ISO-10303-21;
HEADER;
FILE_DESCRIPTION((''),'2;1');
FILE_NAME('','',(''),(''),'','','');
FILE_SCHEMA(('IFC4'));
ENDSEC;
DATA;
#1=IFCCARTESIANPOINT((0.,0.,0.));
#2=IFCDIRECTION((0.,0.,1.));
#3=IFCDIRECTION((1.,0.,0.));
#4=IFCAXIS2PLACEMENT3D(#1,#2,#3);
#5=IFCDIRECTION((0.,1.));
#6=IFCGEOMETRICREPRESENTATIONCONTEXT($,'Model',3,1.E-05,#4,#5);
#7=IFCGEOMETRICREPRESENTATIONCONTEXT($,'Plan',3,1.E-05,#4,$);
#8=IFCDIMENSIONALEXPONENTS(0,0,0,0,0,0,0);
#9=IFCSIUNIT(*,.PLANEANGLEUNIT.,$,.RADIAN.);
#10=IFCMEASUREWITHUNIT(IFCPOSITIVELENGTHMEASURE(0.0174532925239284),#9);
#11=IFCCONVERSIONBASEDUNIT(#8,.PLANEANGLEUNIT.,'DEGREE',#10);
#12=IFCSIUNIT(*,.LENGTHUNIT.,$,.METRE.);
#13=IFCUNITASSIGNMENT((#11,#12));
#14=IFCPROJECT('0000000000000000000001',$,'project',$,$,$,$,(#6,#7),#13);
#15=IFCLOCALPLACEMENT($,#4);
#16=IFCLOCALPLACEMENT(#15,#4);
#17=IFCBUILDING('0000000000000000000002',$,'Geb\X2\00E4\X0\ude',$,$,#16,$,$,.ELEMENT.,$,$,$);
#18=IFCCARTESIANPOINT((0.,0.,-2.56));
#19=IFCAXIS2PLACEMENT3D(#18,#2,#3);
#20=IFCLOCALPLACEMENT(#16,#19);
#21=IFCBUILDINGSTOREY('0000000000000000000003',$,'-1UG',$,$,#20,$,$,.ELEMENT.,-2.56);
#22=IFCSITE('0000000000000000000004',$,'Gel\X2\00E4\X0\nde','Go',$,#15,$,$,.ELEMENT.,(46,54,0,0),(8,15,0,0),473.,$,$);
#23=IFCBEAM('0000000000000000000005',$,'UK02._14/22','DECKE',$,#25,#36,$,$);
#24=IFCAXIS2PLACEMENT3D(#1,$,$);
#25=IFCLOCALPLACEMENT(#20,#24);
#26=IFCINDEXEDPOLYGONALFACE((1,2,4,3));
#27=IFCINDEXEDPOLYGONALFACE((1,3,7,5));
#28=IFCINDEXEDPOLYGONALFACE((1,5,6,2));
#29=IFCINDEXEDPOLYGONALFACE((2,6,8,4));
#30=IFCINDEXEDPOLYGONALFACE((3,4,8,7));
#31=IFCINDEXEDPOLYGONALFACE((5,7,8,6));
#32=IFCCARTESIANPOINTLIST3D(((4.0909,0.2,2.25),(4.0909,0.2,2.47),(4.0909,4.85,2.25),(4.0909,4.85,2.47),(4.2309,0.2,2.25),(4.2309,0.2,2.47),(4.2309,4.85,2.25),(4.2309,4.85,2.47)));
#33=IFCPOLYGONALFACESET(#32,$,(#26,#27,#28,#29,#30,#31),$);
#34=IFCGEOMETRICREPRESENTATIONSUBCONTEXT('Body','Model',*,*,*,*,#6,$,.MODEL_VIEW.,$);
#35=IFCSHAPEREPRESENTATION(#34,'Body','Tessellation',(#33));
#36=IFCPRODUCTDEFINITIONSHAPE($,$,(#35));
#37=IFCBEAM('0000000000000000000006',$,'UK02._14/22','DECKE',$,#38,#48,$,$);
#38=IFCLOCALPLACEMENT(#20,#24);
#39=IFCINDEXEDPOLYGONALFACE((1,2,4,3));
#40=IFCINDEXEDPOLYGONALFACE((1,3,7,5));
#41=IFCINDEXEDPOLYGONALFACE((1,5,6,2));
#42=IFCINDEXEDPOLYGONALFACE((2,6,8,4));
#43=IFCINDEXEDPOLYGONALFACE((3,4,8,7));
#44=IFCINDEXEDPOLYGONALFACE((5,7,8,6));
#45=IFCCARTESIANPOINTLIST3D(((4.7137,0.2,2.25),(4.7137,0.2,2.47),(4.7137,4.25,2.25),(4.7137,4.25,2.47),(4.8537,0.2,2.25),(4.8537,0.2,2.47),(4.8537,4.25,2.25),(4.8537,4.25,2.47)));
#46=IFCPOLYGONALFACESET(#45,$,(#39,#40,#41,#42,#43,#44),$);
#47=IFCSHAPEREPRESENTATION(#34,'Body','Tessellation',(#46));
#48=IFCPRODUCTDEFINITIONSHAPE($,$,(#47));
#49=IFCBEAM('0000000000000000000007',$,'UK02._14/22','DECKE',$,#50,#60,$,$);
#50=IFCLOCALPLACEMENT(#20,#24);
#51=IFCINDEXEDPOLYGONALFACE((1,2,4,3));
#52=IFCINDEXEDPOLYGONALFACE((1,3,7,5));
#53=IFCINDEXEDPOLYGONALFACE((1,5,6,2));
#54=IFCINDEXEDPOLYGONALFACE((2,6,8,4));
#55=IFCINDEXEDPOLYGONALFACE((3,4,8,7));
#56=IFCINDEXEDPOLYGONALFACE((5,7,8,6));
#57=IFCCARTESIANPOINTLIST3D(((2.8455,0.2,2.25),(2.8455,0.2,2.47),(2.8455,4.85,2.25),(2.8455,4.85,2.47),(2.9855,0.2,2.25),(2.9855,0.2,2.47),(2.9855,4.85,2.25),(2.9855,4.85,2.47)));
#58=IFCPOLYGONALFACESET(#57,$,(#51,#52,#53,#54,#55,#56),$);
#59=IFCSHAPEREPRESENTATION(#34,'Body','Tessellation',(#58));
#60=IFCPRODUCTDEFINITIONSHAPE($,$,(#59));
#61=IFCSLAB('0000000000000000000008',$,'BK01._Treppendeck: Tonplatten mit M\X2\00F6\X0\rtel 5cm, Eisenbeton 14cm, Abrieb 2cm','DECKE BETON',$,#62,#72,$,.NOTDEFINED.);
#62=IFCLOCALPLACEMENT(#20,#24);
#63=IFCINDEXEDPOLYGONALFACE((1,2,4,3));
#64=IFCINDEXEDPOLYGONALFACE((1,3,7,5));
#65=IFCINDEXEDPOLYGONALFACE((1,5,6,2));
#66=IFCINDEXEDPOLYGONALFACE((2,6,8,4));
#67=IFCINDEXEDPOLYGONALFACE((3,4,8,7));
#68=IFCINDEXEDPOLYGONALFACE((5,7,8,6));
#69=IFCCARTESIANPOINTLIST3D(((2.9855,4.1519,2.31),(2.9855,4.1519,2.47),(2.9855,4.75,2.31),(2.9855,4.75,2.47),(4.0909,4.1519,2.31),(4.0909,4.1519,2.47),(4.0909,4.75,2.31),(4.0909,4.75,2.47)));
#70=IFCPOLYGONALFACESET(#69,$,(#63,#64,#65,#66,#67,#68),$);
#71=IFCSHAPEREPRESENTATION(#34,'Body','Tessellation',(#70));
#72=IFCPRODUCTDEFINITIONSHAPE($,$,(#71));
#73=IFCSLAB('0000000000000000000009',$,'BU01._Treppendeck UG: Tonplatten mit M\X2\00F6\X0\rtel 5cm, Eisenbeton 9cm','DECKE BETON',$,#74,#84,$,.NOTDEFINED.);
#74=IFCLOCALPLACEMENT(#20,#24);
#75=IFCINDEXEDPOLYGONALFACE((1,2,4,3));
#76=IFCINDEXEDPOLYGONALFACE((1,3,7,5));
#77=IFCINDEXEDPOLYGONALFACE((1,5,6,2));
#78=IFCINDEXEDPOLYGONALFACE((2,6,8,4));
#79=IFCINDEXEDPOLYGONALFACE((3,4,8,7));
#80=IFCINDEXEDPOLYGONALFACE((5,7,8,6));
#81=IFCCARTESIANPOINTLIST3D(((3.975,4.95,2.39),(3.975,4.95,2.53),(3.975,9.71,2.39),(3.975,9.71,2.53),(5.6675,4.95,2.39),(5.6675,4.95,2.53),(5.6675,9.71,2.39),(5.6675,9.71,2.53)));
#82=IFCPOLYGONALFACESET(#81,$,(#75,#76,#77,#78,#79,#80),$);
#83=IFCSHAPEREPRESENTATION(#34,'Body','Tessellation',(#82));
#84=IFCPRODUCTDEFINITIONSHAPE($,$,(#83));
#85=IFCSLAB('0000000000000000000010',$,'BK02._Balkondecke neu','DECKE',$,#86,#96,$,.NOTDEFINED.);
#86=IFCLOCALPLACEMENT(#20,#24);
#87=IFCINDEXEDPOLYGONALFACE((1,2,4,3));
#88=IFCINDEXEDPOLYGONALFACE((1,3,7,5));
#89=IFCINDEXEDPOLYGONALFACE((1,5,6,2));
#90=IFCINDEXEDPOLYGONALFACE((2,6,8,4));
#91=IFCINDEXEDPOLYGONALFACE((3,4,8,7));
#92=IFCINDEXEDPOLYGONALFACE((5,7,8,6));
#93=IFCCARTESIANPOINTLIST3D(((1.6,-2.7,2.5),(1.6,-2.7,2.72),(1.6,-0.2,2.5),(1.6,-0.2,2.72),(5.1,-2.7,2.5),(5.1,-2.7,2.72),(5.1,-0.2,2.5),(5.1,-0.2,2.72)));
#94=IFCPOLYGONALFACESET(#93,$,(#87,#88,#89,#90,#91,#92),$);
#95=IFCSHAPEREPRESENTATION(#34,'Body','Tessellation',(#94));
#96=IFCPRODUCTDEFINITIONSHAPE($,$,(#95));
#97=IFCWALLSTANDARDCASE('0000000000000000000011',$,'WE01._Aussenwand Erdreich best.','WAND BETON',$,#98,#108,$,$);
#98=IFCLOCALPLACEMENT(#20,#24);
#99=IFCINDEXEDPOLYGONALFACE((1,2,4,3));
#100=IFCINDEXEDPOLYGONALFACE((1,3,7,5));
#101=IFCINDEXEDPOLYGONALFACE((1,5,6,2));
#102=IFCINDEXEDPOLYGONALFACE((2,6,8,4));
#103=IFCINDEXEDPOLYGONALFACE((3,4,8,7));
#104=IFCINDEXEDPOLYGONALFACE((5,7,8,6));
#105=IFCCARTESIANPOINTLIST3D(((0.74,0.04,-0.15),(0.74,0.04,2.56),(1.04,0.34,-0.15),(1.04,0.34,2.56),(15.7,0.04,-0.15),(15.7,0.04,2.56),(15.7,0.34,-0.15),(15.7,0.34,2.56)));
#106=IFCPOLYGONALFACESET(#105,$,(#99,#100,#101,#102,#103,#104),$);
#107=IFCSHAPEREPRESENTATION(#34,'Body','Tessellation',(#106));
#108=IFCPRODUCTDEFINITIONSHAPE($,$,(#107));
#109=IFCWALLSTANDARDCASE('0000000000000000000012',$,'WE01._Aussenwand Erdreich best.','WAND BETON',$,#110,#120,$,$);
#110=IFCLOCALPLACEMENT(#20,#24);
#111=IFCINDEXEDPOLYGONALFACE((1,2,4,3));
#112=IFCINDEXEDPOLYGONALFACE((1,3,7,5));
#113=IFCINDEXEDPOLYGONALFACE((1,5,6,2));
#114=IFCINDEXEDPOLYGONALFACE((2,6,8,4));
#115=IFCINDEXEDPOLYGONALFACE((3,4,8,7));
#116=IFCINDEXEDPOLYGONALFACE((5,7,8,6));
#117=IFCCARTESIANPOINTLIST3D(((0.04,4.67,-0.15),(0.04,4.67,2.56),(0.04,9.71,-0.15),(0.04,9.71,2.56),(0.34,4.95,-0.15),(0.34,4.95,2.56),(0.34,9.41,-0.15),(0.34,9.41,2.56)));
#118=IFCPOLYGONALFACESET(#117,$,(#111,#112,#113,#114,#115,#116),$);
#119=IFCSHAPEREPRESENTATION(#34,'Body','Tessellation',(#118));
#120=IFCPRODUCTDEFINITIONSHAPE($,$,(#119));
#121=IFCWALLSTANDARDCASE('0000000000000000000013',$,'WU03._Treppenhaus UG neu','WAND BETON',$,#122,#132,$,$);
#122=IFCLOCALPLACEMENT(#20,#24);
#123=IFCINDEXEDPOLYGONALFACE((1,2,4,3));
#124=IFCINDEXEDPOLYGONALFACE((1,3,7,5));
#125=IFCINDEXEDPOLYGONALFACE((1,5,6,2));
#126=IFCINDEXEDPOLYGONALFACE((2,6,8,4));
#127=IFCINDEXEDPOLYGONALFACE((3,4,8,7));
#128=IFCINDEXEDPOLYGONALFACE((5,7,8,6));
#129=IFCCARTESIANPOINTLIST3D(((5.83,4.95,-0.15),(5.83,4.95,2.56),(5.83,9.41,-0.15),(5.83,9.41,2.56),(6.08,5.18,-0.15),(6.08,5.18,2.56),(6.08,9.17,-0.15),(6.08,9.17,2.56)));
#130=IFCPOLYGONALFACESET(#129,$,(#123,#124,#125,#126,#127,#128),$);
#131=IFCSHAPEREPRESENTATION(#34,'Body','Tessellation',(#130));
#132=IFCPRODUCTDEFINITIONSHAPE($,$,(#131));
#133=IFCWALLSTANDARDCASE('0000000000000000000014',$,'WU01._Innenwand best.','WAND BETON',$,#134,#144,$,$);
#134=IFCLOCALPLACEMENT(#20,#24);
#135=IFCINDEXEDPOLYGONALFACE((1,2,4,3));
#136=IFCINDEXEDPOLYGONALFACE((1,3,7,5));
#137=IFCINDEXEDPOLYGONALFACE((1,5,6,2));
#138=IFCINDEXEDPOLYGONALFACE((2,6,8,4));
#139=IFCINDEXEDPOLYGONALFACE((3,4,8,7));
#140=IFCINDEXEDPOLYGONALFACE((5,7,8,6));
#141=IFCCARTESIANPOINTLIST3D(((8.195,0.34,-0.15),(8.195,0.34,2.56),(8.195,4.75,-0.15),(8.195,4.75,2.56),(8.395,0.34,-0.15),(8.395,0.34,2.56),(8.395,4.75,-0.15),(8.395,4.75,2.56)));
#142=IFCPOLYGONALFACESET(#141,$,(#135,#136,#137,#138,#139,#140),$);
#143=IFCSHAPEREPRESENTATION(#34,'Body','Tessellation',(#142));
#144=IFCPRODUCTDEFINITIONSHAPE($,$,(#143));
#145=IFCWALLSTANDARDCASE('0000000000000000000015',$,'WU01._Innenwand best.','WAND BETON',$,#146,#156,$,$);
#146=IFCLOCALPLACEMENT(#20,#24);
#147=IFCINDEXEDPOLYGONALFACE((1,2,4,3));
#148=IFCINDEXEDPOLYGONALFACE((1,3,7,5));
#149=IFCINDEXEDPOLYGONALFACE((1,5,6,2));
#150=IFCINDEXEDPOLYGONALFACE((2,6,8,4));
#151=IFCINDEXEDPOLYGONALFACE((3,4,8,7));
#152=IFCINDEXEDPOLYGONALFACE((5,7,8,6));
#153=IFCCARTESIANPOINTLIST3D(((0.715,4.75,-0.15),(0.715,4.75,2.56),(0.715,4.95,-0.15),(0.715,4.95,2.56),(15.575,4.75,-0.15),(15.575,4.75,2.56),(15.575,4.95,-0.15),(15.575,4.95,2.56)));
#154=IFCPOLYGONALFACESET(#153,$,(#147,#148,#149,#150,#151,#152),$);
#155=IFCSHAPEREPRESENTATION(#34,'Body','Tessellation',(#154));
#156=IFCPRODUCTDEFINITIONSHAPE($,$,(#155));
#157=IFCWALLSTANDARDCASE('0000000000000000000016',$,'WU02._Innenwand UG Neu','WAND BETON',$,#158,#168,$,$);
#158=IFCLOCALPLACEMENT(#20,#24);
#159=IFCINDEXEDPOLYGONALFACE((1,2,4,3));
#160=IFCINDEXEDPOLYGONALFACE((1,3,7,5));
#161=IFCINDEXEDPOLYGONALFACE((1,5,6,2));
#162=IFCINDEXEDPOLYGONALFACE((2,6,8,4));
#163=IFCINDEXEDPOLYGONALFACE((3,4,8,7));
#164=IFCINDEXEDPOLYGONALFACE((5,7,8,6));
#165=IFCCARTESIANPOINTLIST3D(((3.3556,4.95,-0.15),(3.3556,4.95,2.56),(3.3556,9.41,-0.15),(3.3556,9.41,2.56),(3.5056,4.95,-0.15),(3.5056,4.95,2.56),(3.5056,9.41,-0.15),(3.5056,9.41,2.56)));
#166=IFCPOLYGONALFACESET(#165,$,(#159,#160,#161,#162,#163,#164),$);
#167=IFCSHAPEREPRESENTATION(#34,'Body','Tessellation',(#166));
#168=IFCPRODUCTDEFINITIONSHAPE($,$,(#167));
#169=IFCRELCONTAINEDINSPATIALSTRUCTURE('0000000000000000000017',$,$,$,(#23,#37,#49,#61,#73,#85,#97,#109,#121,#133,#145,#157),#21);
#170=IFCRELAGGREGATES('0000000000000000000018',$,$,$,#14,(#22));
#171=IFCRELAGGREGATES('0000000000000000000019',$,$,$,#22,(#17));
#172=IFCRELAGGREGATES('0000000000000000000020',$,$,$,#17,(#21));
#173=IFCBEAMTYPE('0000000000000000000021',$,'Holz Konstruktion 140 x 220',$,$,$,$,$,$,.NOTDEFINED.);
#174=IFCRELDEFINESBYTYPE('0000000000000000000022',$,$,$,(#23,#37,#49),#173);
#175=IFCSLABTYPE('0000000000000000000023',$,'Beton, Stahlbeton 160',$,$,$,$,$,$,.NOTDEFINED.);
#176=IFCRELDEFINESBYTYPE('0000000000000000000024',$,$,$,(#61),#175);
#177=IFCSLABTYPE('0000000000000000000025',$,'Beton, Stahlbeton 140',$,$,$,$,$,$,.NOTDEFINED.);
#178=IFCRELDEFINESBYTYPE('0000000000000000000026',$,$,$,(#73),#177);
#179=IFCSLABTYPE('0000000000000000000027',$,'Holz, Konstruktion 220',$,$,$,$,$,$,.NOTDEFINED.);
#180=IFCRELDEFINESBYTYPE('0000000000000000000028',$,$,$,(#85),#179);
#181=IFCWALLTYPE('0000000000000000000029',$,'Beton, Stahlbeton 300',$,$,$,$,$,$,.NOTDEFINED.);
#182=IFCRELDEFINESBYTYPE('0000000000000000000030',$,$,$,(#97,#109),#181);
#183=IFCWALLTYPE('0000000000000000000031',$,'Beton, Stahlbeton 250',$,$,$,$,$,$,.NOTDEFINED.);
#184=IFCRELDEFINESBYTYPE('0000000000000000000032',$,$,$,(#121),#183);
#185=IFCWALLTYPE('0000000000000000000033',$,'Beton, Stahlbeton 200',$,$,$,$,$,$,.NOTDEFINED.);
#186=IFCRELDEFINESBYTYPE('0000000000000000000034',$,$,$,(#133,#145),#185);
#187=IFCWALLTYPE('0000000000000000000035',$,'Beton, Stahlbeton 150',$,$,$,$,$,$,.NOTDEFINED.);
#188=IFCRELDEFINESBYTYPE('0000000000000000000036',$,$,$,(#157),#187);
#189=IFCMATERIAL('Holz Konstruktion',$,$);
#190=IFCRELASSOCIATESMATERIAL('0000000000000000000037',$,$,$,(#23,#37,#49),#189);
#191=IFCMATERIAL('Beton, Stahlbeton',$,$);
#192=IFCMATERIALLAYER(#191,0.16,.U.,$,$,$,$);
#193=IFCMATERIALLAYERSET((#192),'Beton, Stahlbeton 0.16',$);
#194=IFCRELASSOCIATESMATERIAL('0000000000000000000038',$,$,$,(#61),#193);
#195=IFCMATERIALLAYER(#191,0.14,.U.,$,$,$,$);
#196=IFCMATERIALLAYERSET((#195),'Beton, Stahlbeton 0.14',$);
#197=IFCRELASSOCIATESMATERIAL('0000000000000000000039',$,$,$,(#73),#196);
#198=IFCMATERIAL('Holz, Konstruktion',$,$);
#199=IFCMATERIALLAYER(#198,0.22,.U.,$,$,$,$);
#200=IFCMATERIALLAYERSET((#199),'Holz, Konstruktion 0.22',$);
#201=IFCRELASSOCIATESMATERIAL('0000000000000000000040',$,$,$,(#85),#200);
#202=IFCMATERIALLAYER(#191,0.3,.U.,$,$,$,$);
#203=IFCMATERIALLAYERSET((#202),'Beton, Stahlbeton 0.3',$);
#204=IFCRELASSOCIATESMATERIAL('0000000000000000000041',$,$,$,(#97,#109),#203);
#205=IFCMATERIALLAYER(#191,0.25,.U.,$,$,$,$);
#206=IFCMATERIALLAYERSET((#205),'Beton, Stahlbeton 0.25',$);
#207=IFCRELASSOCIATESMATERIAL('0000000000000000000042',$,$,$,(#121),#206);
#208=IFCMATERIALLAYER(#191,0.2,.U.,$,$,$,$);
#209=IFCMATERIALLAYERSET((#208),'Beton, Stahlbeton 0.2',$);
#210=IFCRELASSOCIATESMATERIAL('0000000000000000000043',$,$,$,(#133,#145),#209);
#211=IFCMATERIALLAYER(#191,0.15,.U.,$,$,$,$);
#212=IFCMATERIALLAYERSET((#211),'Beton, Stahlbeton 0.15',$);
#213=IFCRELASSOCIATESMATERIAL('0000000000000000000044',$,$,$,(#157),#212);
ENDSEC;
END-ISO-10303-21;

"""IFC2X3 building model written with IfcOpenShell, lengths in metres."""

from ifc_helpers import new_model, entity, si_unit, converted_unit, direction, frame, frame_2d, origin_with_axes, place, context, subcontext, project, spatial, polyline, rectangle, outline, extrude, material, layer, layer_set, layer_usage, type_object, element, save


model = new_model("IFC2X3")

# Units and contexts
model_context = context("Model", 3, precision=1e-05, world=origin_with_axes(), true_north=direction((0.0, 1.0)))
plan_context = context("Plan", 3, precision=1e-05, world=origin_with_axes())
body_context = subcontext(model_context, "Body", "Model", "MODEL_VIEW")
ifc_project = project(units=[converted_unit("PLANEANGLEUNIT", "DEGREE", entity("IfcPositiveLengthMeasure", 0.0174532925239284), si_unit("PLANEANGLEUNIT", "RADIAN"), dimensions=[0, 0, 0, 0, 0, 0, 0]), si_unit("LENGTHUNIT", "METRE")], contexts=[model_context, plan_context])

# Site, building, storey
site_placement = place(None, origin_with_axes())
site = spatial("IfcSite", under=ifc_project, at=site_placement, Name="Gelände", Description="Go", CompositionType="ELEMENT", RefLatitude=(46, 54, 0, 0), RefLongitude=(8, 15, 0, 0), RefElevation=473.0)
building_placement = place(site_placement, origin_with_axes())
building = spatial("IfcBuilding", under=site, at=building_placement, Name="Gebäude", CompositionType="ELEMENT")
storey_placement = place(building_placement, frame((0.0, 0.0, -2.56), z_axis=(0.0, 0.0, 1.0), x_axis=(1.0, 0.0, 0.0)))
storey = spatial("IfcBuildingStorey", under=building, at=storey_placement, Name="-1UG", CompositionType="ELEMENT", Elevation=-2.56)

# Shared definitions
ifc_material_1 = material(Name="Beton, Stahlbeton")

# Beams
ifc_material_2 = material(Name="Holz Konstruktion")
beam_type_1 = type_object("IfcBeamType", Name="Holz Konstruktion 140 x 220", PredefinedType="NOTDEFINED")
for number, where, z_axis, x_axis, name in (
    (1, (4.1609, 0.2, 2.47), (0.0, 0.0, 1.0), (1.0, 0.0, 0.0), "UK02._14/22"),
):
    element("IfcBeam", number, at=place(storey_placement, frame(where, z_axis=z_axis, x_axis=x_axis)), inside=storey, type_object=beam_type_1, material=ifc_material_2, Name=name, Description="DECKE", context=body_context, shape_type="SweptSolid", body=[
        extrude(rectangle(XDim=0.22, YDim=0.14, at=frame_2d((-0.11, 0.0), x_axis=(1.0, 0.0))), frame((0.0, 0.0, 0.0), z_axis=(0.0, 1.0, 0.0), x_axis=(0.0, 0.0, 1.0)), (0.0, 0.0, 1.0), 4.65),
    ])
beam_1_placement = place(storey_placement, frame((4.7837, 0.2, 2.47), z_axis=(0.0, 0.0, 1.0), x_axis=(1.0, 0.0, 0.0)))
element("IfcBeam", 2, at=beam_1_placement, inside=storey, type_object=beam_type_1, material=ifc_material_2, Name="UK02._14/22", Description="DECKE", context=body_context, shape_type="SweptSolid", body=[
    extrude(rectangle(XDim=0.22, YDim=0.14, at=frame_2d((-0.11, 0.0), x_axis=(1.0, 0.0))), frame((0.0, 0.0, 0.0), z_axis=(0.0, 1.0, 0.0), x_axis=(0.0, 0.0, 1.0)), (0.0, 0.0, 1.0), 4.05),
])
beam_2_placement = place(storey_placement, frame((2.9155, 0.2, 2.47), z_axis=(0.0, 0.0, 1.0), x_axis=(1.0, 0.0, 0.0)))
element("IfcBeam", 3, at=beam_2_placement, inside=storey, type_object=beam_type_1, material=ifc_material_2, Name="UK02._14/22", Description="DECKE", context=body_context, shape_type="SweptSolid", body=[
    extrude(rectangle(XDim=0.22, YDim=0.14, at=frame_2d((-0.11, 0.0), x_axis=(1.0, 0.0))), frame((0.0, 0.0, 0.0), z_axis=(0.0, 1.0, 0.0), x_axis=(0.0, 0.0, 1.0)), (0.0, 0.0, 1.0), 4.65),
])

# Slabs
ifc_layer_1 = layer(ifc_material_1, 0.16, ventilated="UNKNOWN")
ifc_layer_set_1 = layer_set([ifc_layer_1], Name="Beton, Stahlbeton 0.16")
ifc_layer_usage_1 = layer_usage(ifc_layer_set_1, "AXIS3", "NEGATIVE", 0.16)
slab_type_1 = type_object("IfcSlabType", Name="Beton, Stahlbeton 160", PredefinedType="NOTDEFINED")
slab_1_placement = place(storey_placement, frame((4.0909, 4.1519, 2.47), z_axis=(0.0, 0.0, 1.0), x_axis=(1.0, 0.0, 0.0)))
element("IfcSlab", 4, at=slab_1_placement, inside=storey, type_object=slab_type_1, material=ifc_layer_usage_1, Name="BK01._Treppendeck: Tonplatten mit Mörtel 5cm, Eisenbeton 14cm, Abrieb 2cm", Description="DECKE BETON", PredefinedType="NOTDEFINED", context=body_context, shape_type="SweptSolid", body=[
    extrude(outline(polyline([(0.0, 0.0), (0.0, 0.5981), (-1.1054, 0.5981), (-1.1054, 0.0), (0.0, 0.0)])), frame((0.0, 0.0, -0.16), z_axis=(0.0, 0.0, 1.0), x_axis=(1.0, 0.0, 0.0)), (0.0, 0.0, 1.0), 0.16),
])
ifc_layer_2 = layer(ifc_material_1, 0.14, ventilated="UNKNOWN")
ifc_layer_set_2 = layer_set([ifc_layer_2], Name="Beton, Stahlbeton 0.14")
ifc_layer_usage_2 = layer_usage(ifc_layer_set_2, "AXIS3", "NEGATIVE", 0.14)
slab_type_2 = type_object("IfcSlabType", Name="Beton, Stahlbeton 140", PredefinedType="NOTDEFINED")
slab_2_placement = place(storey_placement, frame((5.6675, 4.95, 2.53), z_axis=(0.0, 0.0, 1.0), x_axis=(1.0, 0.0, 0.0)))
element("IfcSlab", 5, at=slab_2_placement, inside=storey, type_object=slab_type_2, material=ifc_layer_usage_2, Name="BU01._Treppendeck UG: Tonplatten mit Mörtel 5cm, Eisenbeton 9cm", Description="DECKE BETON", PredefinedType="NOTDEFINED", context=body_context, shape_type="SweptSolid", body=[
    extrude(outline(polyline([(0.0, 0.0), (0.0, 4.76), (-1.6925, 4.76), (-1.6925, 0.0), (0.0, 0.0)])), frame((0.0, 0.0, -0.14), z_axis=(0.0, 0.0, 1.0), x_axis=(1.0, 0.0, 0.0)), (0.0, 0.0, 1.0), 0.14),
])
ifc_material_3 = material(Name="Holz, Konstruktion")
ifc_layer_3 = layer(ifc_material_3, 0.22, ventilated="UNKNOWN")
ifc_layer_set_3 = layer_set([ifc_layer_3], Name="Holz, Konstruktion 0.22")
ifc_layer_usage_3 = layer_usage(ifc_layer_set_3, "AXIS3", "NEGATIVE", 0.22)
slab_type_3 = type_object("IfcSlabType", Name="Holz, Konstruktion 220", PredefinedType="NOTDEFINED")
slab_3_placement = place(storey_placement, frame((1.6, -2.7, 2.72), z_axis=(0.0, 0.0, 1.0), x_axis=(1.0, 0.0, 0.0)))
element("IfcSlab", 6, at=slab_3_placement, inside=storey, type_object=slab_type_3, material=ifc_layer_usage_3, Name="BK02._Balkondecke neu", Description="DECKE", PredefinedType="NOTDEFINED", context=body_context, shape_type="SweptSolid", body=[
    extrude(outline(polyline([(0.0, 0.0), (3.5, 0.0), (3.5, 2.5), (0.0, 2.5), (0.0, 0.0)])), frame((0.0, 0.0, -0.22), z_axis=(0.0, 0.0, 1.0), x_axis=(1.0, 0.0, 0.0)), (0.0, 0.0, 1.0), 0.22),
])

# Walls
ifc_layer_4 = layer(ifc_material_1, 0.3, ventilated="UNKNOWN")
ifc_layer_set_4 = layer_set([ifc_layer_4], Name="Beton, Stahlbeton 0.3")
wall_type_1 = type_object("IfcWallType", Name="Beton, Stahlbeton 300", PredefinedType="NOTDEFINED")
ifc_layer_usage_4 = layer_usage(ifc_layer_set_4, "AXIS2", "POSITIVE", -0.3)
wall_1_placement = place(storey_placement, frame((1.04, 0.34, -0.15), z_axis=(0.0, 0.0, 1.0), x_axis=(1.0, 0.0, 0.0)))
element("IfcWallStandardCase", 7, at=wall_1_placement, inside=storey, type_object=wall_type_1, material=ifc_layer_usage_4, Name="WE01._Aussenwand Erdreich best.", Description="WAND BETON", context=body_context, shape_type="SweptSolid", body=[
    extrude(outline(polyline([(-0.3, -0.3), (14.66, -0.3), (14.66, 0.0), (0.0, 0.0), (-0.3, -0.3)])), origin_with_axes(), (0.0, 0.0, 1.0), 2.71),
])
ifc_layer_usage_5 = layer_usage(ifc_layer_set_4, "AXIS2", "POSITIVE", -0.3)
wall_2_placement = place(storey_placement, frame((0.34, 9.41, -0.15), z_axis=(0.0, 0.0, 1.0), x_axis=(0.0, -1.0, 0.0)))
element("IfcWallStandardCase", 8, at=wall_2_placement, inside=storey, type_object=wall_type_1, material=ifc_layer_usage_5, Name="WE01._Aussenwand Erdreich best.", Description="WAND BETON", context=body_context, shape_type="SweptSolid", body=[
    extrude(outline(polyline([(-0.3, -0.3), (4.74, -0.3), (4.46, 0.0), (0.0, 0.0), (-0.3, -0.3)])), origin_with_axes(), (0.0, 0.0, 1.0), 2.71),
])
ifc_layer_5 = layer(ifc_material_1, 0.25, ventilated="UNKNOWN")
ifc_layer_set_5 = layer_set([ifc_layer_5], Name="Beton, Stahlbeton 0.25")
ifc_layer_usage_6 = layer_usage(ifc_layer_set_5, "AXIS2", "POSITIVE", -0.25)
wall_type_2 = type_object("IfcWallType", Name="Beton, Stahlbeton 250", PredefinedType="NOTDEFINED")
wall_3_placement = place(storey_placement, frame((6.08, 9.17, -0.15), z_axis=(0.0, 0.0, 1.0), x_axis=(0.0, -1.0, 0.0)))
element("IfcWallStandardCase", 9, at=wall_3_placement, inside=storey, type_object=wall_type_2, material=ifc_layer_usage_6, Name="WU03._Treppenhaus UG neu", Description="WAND BETON", context=body_context, shape_type="SweptSolid", body=[
    extrude(outline(polyline([(-0.24, -0.25), (4.22, -0.25), (3.99, 0.0), (0.0, 0.0), (-0.24, -0.25)])), origin_with_axes(), (0.0, 0.0, 1.0), 2.71),
])
ifc_layer_6 = layer(ifc_material_1, 0.2, ventilated="UNKNOWN")
ifc_layer_set_6 = layer_set([ifc_layer_6], Name="Beton, Stahlbeton 0.2")
ifc_layer_usage_7 = layer_usage(ifc_layer_set_6, "AXIS2", "POSITIVE", 0.0)
wall_type_3 = type_object("IfcWallType", Name="Beton, Stahlbeton 200", PredefinedType="NOTDEFINED")
wall_4_placement = place(storey_placement, frame((8.395, 0.34, -0.15), z_axis=(0.0, 0.0, 1.0), x_axis=(0.0, 1.0, 0.0)))
element("IfcWallStandardCase", 10, at=wall_4_placement, inside=storey, type_object=wall_type_3, material=ifc_layer_usage_7, Name="WU01._Innenwand best.", Description="WAND BETON", context=body_context, shape_type="SweptSolid", body=[
    extrude(outline(polyline([(0.0, 0.0), (4.41, 0.0), (4.41, 0.2), (0.0, 0.2), (0.0, 0.0)])), origin_with_axes(), (0.0, 0.0, 1.0), 2.71),
])
ifc_layer_usage_8 = layer_usage(ifc_layer_set_6, "AXIS2", "NEGATIVE", 0.0)
wall_5_placement = place(storey_placement, frame((0.715, 4.95, -0.15), z_axis=(0.0, 0.0, 1.0), x_axis=(1.0, 0.0, 0.0)))
element("IfcWallStandardCase", 11, at=wall_5_placement, inside=storey, type_object=wall_type_3, material=ifc_layer_usage_8, Name="WU01._Innenwand best.", Description="WAND BETON", context=body_context, shape_type="SweptSolid", body=[
    extrude(outline(polyline([(0.0, -0.2), (14.86, -0.2), (14.86, 0.0), (0.0, 0.0), (0.0, -0.2)])), origin_with_axes(), (0.0, 0.0, 1.0), 2.71),
])
ifc_layer_7 = layer(ifc_material_1, 0.15, ventilated="UNKNOWN")
ifc_layer_set_7 = layer_set([ifc_layer_7], Name="Beton, Stahlbeton 0.15")
ifc_layer_usage_9 = layer_usage(ifc_layer_set_7, "AXIS2", "NEGATIVE", 0.0)
wall_type_4 = type_object("IfcWallType", Name="Beton, Stahlbeton 150", PredefinedType="NOTDEFINED")
wall_6_placement = place(storey_placement, frame((3.5056, 9.41, -0.15), z_axis=(0.0, 0.0, 1.0), x_axis=(0.0, -1.0, 0.0)))
element("IfcWallStandardCase", 12, at=wall_6_placement, inside=storey, type_object=wall_type_4, material=ifc_layer_usage_9, Name="WU02._Innenwand UG Neu", Description="WAND BETON", context=body_context, shape_type="SweptSolid", body=[
    extrude(outline(polyline([(0.0, -0.15), (4.46, -0.15), (4.46, 0.0), (0.0, 0.0), (0.0, -0.15)])), origin_with_axes(), (0.0, 0.0, 1.0), 2.71),
])

save(model, "model.ifc")
